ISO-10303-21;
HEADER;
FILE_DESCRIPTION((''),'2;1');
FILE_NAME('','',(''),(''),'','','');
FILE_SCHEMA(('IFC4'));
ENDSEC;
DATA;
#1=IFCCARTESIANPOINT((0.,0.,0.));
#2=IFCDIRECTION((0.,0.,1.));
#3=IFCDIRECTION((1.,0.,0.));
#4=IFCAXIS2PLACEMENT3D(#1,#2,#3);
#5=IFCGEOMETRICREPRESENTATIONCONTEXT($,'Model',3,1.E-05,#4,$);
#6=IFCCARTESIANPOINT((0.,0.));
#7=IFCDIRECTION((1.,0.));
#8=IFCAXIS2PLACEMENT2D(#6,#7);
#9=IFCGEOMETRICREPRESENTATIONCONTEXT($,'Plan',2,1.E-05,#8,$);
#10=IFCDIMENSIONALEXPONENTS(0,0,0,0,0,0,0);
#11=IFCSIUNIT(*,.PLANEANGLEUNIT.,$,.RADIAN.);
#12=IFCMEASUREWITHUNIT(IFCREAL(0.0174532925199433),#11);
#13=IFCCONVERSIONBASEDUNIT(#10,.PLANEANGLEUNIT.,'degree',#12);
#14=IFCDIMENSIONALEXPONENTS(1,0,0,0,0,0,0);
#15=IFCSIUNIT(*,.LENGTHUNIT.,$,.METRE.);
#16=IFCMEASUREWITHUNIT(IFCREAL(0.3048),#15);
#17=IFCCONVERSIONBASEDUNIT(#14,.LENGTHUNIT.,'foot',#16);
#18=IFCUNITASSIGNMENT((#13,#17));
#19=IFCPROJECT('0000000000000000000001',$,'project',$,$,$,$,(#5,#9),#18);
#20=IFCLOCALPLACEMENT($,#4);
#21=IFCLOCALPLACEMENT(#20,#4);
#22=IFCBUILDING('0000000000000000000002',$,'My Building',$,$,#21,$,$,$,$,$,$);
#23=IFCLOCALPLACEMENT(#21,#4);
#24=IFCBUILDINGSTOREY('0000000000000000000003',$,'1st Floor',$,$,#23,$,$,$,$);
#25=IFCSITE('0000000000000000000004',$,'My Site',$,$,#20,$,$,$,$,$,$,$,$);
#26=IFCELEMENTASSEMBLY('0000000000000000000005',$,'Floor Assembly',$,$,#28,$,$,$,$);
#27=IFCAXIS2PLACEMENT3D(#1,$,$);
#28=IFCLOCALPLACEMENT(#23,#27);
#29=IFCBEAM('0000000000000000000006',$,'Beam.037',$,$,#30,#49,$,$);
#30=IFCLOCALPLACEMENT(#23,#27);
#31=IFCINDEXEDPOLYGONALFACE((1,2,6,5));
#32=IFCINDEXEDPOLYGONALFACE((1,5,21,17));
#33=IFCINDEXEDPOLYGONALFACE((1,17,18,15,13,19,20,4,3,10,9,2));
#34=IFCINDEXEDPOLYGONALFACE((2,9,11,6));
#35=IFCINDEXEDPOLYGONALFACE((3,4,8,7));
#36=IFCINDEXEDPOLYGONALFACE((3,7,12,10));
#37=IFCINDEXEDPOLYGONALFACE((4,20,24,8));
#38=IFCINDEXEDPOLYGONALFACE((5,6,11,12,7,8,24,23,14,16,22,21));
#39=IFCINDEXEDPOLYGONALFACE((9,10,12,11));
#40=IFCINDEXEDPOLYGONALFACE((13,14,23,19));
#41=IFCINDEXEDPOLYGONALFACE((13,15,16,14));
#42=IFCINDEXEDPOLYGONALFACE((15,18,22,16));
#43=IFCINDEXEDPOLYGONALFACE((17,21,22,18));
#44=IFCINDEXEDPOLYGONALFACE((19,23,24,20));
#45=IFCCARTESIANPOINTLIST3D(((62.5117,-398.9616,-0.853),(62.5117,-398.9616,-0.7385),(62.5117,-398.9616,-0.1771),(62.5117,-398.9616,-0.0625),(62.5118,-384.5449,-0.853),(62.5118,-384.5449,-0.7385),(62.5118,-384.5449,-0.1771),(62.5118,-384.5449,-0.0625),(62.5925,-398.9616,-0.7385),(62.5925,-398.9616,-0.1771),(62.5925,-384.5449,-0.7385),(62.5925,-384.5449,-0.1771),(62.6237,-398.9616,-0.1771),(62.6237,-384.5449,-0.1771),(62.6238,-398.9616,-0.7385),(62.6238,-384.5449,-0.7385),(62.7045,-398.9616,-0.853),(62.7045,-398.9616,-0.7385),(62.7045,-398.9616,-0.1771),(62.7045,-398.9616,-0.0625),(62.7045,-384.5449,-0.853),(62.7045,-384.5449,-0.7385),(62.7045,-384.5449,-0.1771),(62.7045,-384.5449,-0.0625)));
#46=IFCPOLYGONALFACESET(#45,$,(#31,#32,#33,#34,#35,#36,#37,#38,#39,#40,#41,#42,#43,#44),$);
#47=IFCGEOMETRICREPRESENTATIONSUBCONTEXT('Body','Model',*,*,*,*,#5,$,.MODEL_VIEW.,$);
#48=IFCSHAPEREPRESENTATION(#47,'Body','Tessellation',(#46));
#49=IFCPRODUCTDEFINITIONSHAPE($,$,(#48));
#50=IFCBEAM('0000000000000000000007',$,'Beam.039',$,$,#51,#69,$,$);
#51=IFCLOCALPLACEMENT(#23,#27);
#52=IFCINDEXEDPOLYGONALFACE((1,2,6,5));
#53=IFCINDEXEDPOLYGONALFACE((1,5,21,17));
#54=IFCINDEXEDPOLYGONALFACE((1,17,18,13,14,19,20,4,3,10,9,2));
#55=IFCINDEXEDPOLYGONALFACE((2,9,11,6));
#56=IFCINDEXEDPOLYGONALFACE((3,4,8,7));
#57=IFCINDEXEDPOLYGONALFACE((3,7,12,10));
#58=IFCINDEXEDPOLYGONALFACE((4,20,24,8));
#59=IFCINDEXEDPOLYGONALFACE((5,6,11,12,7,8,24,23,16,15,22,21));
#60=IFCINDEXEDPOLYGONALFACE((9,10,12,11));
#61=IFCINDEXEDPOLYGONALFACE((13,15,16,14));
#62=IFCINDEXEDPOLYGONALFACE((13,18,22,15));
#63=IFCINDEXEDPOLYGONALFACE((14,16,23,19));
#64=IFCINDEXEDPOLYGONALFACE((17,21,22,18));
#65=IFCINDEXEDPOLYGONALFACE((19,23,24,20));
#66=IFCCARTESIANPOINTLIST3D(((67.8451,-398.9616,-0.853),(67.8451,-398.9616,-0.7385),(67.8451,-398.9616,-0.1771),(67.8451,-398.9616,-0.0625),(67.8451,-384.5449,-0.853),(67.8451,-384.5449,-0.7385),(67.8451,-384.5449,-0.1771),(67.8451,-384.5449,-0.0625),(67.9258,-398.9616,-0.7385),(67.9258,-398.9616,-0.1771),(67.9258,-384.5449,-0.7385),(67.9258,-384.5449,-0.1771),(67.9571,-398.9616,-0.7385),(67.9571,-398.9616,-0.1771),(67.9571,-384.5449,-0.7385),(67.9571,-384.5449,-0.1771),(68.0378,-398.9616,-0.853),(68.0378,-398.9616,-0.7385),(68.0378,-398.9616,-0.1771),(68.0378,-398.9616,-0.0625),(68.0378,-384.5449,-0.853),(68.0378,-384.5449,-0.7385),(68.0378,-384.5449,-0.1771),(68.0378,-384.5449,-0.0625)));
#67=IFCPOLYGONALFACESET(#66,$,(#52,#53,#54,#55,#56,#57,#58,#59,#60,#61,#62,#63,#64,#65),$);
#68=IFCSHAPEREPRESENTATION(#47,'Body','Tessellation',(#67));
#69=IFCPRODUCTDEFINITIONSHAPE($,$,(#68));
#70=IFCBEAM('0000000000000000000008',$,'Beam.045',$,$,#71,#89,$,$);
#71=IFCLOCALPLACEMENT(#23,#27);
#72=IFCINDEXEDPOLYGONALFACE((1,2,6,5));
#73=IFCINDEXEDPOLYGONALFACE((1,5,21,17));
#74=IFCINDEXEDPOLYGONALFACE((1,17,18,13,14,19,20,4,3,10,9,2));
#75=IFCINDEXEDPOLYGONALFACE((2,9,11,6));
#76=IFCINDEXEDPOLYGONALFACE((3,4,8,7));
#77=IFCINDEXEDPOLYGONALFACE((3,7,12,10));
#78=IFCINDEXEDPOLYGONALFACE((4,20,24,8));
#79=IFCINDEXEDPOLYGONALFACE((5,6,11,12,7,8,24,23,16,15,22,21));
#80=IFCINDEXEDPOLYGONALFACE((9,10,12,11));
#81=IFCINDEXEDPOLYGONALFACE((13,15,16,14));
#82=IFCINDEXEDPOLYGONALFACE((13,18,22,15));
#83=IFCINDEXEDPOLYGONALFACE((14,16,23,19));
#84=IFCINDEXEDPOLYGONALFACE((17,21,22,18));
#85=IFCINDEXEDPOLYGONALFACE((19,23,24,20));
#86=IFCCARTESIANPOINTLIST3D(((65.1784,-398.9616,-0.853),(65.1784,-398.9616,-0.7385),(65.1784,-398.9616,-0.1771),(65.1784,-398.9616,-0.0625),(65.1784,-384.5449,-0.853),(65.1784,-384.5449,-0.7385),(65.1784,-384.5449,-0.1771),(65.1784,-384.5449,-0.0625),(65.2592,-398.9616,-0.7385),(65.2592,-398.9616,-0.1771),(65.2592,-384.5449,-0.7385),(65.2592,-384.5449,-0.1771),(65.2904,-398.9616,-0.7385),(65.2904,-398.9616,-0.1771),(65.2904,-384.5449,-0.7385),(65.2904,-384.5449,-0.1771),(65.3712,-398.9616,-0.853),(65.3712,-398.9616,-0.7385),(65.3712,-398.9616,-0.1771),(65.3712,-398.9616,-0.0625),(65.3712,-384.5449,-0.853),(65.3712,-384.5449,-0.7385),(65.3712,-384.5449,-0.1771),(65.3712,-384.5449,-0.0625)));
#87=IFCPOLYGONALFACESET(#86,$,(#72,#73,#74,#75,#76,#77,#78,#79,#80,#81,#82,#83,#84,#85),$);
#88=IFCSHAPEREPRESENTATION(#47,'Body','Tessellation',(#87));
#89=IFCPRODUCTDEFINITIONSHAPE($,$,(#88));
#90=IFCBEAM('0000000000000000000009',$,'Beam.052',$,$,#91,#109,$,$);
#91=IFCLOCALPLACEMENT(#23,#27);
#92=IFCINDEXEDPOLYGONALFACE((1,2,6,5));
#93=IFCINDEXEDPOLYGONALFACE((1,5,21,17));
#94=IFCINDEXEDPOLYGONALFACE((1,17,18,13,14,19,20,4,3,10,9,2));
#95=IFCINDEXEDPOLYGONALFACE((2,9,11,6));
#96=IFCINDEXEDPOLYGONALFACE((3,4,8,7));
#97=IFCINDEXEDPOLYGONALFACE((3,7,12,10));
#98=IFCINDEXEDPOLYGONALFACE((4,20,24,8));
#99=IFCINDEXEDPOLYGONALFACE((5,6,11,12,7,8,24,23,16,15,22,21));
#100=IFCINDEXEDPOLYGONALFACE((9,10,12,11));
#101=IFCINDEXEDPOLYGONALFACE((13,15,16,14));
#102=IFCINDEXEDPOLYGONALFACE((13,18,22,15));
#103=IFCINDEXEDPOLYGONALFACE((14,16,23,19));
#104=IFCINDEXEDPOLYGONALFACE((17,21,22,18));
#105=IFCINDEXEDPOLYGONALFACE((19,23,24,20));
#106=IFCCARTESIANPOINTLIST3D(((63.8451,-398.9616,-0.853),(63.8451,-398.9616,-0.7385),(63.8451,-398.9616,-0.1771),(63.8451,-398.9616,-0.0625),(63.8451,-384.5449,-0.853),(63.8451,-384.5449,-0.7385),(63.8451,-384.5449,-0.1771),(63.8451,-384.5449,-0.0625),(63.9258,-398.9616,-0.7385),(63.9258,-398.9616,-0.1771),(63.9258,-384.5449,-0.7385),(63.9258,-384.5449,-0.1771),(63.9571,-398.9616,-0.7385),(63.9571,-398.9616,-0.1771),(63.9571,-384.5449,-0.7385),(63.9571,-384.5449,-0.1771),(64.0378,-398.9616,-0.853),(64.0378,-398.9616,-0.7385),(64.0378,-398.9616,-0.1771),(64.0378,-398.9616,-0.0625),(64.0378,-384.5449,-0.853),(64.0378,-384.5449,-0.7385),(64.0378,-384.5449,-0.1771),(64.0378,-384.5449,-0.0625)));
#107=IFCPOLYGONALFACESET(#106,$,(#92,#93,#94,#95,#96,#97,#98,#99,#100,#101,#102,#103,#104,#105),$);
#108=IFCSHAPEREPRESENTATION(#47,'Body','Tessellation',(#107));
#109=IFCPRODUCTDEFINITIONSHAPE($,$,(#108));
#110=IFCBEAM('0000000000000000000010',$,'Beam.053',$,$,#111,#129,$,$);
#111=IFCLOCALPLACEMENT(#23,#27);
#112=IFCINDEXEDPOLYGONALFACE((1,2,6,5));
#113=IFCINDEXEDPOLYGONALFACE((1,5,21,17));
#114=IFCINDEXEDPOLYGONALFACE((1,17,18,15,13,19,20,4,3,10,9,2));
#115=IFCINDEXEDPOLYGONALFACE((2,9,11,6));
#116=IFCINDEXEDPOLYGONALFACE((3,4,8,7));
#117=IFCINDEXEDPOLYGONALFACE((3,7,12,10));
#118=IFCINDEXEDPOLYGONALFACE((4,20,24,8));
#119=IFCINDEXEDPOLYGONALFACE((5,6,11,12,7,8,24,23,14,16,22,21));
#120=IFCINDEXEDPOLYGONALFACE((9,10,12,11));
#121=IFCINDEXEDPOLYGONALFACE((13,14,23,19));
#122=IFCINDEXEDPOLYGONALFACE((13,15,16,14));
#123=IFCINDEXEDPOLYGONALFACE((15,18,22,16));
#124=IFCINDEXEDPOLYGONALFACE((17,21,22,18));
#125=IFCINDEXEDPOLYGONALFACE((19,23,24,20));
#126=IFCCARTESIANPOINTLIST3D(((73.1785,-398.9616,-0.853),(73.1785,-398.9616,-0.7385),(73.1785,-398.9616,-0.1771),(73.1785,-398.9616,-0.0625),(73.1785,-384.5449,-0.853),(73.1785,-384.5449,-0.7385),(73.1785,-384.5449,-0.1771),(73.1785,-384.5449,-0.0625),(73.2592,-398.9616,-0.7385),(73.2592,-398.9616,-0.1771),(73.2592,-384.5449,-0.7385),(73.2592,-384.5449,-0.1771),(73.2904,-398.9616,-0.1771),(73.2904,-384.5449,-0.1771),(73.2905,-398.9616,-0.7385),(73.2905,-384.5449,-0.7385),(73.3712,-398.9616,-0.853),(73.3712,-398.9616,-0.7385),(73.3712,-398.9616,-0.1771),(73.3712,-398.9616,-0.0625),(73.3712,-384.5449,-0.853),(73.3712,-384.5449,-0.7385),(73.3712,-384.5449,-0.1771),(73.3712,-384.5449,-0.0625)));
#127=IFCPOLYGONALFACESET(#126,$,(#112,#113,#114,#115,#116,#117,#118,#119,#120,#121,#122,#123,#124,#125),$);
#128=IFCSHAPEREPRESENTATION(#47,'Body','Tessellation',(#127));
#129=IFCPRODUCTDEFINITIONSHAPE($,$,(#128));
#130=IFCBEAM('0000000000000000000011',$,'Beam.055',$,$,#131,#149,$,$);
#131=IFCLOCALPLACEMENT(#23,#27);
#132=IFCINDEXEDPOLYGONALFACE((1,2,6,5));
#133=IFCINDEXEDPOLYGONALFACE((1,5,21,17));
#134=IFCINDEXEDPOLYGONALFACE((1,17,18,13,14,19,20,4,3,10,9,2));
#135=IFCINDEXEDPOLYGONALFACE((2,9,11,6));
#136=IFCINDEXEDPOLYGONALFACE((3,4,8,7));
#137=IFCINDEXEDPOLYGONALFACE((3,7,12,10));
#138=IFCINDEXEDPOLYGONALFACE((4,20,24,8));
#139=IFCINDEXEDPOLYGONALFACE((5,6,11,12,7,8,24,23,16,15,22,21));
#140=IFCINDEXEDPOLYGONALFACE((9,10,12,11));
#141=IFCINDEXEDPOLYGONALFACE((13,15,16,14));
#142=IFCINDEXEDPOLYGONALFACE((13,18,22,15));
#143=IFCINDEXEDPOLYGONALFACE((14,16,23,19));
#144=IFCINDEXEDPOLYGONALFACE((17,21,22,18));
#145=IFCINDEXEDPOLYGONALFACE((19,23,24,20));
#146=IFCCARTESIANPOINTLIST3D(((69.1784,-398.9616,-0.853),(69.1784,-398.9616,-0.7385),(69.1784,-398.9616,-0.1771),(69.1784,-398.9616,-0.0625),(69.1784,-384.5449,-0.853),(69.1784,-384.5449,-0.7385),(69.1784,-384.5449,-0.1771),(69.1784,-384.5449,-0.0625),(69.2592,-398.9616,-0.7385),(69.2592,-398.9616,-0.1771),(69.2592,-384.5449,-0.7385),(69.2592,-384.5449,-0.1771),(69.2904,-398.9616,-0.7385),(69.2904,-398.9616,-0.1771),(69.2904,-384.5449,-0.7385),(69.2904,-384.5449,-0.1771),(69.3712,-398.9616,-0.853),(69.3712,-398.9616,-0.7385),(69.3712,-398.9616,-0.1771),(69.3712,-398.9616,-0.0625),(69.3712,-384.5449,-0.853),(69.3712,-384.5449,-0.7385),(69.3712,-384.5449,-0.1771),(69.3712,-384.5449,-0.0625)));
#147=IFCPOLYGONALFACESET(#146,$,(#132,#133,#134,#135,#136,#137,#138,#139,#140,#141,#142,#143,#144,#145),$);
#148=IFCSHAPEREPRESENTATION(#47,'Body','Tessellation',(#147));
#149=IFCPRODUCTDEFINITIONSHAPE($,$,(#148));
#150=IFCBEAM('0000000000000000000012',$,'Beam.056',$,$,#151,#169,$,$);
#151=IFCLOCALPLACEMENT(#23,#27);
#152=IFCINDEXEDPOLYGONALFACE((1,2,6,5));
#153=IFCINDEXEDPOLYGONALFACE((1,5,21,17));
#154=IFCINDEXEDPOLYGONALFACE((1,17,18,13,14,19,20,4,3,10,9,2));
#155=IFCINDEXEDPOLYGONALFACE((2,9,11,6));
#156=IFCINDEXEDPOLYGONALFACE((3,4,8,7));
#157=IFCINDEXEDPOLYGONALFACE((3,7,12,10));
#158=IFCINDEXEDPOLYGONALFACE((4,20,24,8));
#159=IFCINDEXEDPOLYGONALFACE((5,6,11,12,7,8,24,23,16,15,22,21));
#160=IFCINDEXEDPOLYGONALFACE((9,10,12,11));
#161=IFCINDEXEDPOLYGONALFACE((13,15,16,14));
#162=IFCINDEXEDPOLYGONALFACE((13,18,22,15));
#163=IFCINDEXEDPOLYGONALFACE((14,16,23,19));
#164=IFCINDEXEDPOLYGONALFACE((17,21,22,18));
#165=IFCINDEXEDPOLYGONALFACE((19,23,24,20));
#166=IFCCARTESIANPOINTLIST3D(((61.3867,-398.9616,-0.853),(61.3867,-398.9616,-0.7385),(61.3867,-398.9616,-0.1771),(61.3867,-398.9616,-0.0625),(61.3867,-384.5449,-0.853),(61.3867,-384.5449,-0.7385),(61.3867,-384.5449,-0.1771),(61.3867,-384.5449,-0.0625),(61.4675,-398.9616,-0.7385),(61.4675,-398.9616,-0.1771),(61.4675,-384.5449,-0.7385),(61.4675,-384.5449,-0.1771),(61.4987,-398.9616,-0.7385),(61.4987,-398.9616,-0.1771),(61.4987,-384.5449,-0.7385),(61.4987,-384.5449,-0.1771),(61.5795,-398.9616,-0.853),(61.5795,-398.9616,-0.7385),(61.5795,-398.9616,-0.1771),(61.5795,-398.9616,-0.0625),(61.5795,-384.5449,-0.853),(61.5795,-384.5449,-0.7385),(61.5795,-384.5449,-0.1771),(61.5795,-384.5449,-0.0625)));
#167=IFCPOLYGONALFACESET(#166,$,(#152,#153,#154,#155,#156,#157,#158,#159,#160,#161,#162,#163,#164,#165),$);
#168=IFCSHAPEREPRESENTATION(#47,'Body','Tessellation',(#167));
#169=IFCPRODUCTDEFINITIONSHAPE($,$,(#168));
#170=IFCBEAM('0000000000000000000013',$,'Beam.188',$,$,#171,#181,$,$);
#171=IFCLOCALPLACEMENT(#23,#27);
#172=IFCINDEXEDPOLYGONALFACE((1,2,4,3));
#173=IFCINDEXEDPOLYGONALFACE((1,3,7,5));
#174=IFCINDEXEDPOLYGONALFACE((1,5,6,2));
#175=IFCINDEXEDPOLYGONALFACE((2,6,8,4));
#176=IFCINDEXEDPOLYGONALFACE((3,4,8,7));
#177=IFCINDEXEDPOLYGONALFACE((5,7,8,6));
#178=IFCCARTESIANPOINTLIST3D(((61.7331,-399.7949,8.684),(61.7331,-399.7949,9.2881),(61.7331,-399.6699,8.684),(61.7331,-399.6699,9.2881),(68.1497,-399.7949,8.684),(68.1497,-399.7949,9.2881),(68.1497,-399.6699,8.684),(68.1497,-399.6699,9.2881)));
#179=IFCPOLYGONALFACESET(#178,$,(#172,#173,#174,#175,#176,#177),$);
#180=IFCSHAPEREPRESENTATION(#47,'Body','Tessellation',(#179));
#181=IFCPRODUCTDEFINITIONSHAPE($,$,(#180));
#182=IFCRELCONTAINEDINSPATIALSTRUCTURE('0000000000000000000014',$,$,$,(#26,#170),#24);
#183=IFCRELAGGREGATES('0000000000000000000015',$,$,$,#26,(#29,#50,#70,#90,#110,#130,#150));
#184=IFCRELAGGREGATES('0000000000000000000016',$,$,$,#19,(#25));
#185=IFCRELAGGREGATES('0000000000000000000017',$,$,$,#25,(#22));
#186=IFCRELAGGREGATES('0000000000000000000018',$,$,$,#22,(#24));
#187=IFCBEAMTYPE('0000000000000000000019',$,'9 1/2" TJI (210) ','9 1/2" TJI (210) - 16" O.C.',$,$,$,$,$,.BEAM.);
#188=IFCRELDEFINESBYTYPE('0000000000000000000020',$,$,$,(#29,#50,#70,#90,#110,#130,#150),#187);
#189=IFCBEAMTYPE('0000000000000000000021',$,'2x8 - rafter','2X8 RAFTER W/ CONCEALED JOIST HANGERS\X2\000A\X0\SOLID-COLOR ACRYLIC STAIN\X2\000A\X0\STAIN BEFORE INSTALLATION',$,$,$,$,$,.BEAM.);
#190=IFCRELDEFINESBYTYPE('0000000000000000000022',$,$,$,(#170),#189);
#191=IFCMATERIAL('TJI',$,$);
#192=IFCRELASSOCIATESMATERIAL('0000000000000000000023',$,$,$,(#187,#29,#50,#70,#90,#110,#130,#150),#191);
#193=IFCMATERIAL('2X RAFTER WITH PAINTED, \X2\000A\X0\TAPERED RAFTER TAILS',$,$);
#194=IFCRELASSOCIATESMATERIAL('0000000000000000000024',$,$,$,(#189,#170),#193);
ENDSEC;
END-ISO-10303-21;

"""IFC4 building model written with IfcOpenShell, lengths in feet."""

from ifc_helpers import new_model, entity, si_unit, converted_unit, frame, origin_with_axes, origin_2d_with_axis, place, context, subcontext, project, spatial, indexed_curve, rectangle, outline, extrude, material, material_profile, profile_set, profile_usage, type_object, element, aggregate, save


model = new_model("IFC4")

# Units and contexts
model_context = context("Model", 3, precision=1e-05, world=origin_with_axes())
plan_context = context("Plan", 2, precision=1e-05, world=origin_2d_with_axis())
body_context = subcontext(model_context, "Body", "Model", "MODEL_VIEW")
ifc_project = project(units=[converted_unit("PLANEANGLEUNIT", "degree", entity("IfcReal", 0.0174532925199433), si_unit("PLANEANGLEUNIT", "RADIAN"), dimensions=[0, 0, 0, 0, 0, 0, 0]), converted_unit("LENGTHUNIT", "foot", entity("IfcReal", 0.3048), si_unit("LENGTHUNIT", "METRE"), dimensions=[1, 0, 0, 0, 0, 0, 0])], contexts=[model_context, plan_context])

# Site, building, storey
site_placement = place(None, origin_with_axes())
site = spatial("IfcSite", under=ifc_project, at=site_placement, Name="My Site")
building_placement = place(site_placement, origin_with_axes())
building = spatial("IfcBuilding", under=site, at=building_placement, Name="My Building")
storey_placement = place(building_placement, origin_with_axes())
storey = spatial("IfcBuildingStorey", under=building, at=storey_placement, Name="1st Floor")

# Element assembly
assembly_1_placement = place(storey_placement, frame((61.1784, -398.9616, -0.0625), z_axis=(0.0, 0.0, 1.0), x_axis=(0.0, 1.0, 0.0)))
assembly_1 = element("IfcElementAssembly", 1, at=assembly_1_placement, inside=storey, Name="Floor Assembly")

# Beams
ifc_material_1 = material(Name="TJI")
ifc_material_profile_1 = material_profile(ifc_material_1, outline(indexed_curve([(0.0964, 0.7905), (-0.0964, 0.7905), (-0.0964, 0.6759), (-0.0156, 0.6759), (-0.0156, 0.1146), (-0.0964, 0.1146), (-0.0964, 0.0), (0.0964, 0.0), (0.0964, 0.1146), (0.0156, 0.1146), (0.0157, 0.6759), (0.0964, 0.6759), (0.0964, 0.7905)])))
ifc_profile_set_1 = profile_set([ifc_material_profile_1])
beam_type_1 = type_object("IfcBeamType", Name="9 1/2\" TJI (210) ", Description="9 1/2\" TJI (210) - 16\" O.C.", PredefinedType="BEAM", material=ifc_profile_set_1)
ifc_profile_usage_1 = profile_usage(ifc_profile_set_1, cardinal=5)
beam_1_placement = place(assembly_1_placement, frame((0.0, -1.4297, -0.7905), z_axis=(1.0, 0.0, 0.0), x_axis=(0.0, 1.0, 0.0)))
beam_1 = element("IfcBeam", 2, at=beam_1_placement, type_object=beam_type_1, material=ifc_profile_usage_1, Name="Beam.037", context=body_context, shape_type="SweptSolid", body=[
    extrude(outline(indexed_curve([(0.0964, 0.7905), (-0.0964, 0.7905), (-0.0964, 0.6759), (-0.0156, 0.6759), (-0.0156, 0.1146), (-0.0964, 0.1146), (-0.0964, 0.0), (0.0964, 0.0), (0.0964, 0.1146), (0.0156, 0.1146), (0.0157, 0.6759), (0.0964, 0.6759), (0.0964, 0.7905)])), origin_with_axes(), (0.0, 0.0, 1.0), 14.4167),
])
ifc_profile_usage_2 = profile_usage(ifc_profile_set_1, cardinal=5)
beam_2_placement = place(assembly_1_placement, frame((0.0, -6.763, -0.7905), z_axis=(1.0, 0.0, 0.0), x_axis=(0.0, 1.0, 0.0)))
beam_2 = element("IfcBeam", 3, at=beam_2_placement, type_object=beam_type_1, material=ifc_profile_usage_2, Name="Beam.039", context=body_context, shape_type="SweptSolid", body=[
    extrude(outline(indexed_curve([(0.0964, 0.7905), (-0.0964, 0.7905), (-0.0964, 0.6759), (-0.0156, 0.6759), (-0.0156, 0.1146), (-0.0964, 0.1146), (-0.0964, 0.0), (0.0964, 0.0), (0.0964, 0.1146), (0.0156, 0.1146), (0.0157, 0.6759), (0.0964, 0.6759), (0.0964, 0.7905)])), origin_with_axes(), (0.0, 0.0, 1.0), 14.4167),
])
ifc_profile_usage_3 = profile_usage(ifc_profile_set_1, cardinal=5)
beam_3_placement = place(assembly_1_placement, frame((0.0, -4.0964, -0.7905), z_axis=(1.0, 0.0, 0.0), x_axis=(0.0, 1.0, 0.0)))
beam_3 = element("IfcBeam", 4, at=beam_3_placement, type_object=beam_type_1, material=ifc_profile_usage_3, Name="Beam.045", context=body_context, shape_type="SweptSolid", body=[
    extrude(outline(indexed_curve([(0.0964, 0.7905), (-0.0964, 0.7905), (-0.0964, 0.6759), (-0.0156, 0.6759), (-0.0156, 0.1146), (-0.0964, 0.1146), (-0.0964, 0.0), (0.0964, 0.0), (0.0964, 0.1146), (0.0156, 0.1146), (0.0157, 0.6759), (0.0964, 0.6759), (0.0964, 0.7905)])), origin_with_axes(), (0.0, 0.0, 1.0), 14.4167),
])
ifc_profile_usage_4 = profile_usage(ifc_profile_set_1, cardinal=5)
beam_4_placement = place(assembly_1_placement, frame((0.0, -2.763, -0.7905), z_axis=(1.0, 0.0, 0.0), x_axis=(0.0, 1.0, 0.0)))
beam_4 = element("IfcBeam", 5, at=beam_4_placement, type_object=beam_type_1, material=ifc_profile_usage_4, Name="Beam.052", context=body_context, shape_type="SweptSolid", body=[
    extrude(outline(indexed_curve([(0.0964, 0.7905), (-0.0964, 0.7905), (-0.0964, 0.6759), (-0.0156, 0.6759), (-0.0156, 0.1146), (-0.0964, 0.1146), (-0.0964, 0.0), (0.0964, 0.0), (0.0964, 0.1146), (0.0156, 0.1146), (0.0157, 0.6759), (0.0964, 0.6759), (0.0964, 0.7905)])), origin_with_axes(), (0.0, 0.0, 1.0), 14.4167),
])
ifc_profile_usage_5 = profile_usage(ifc_profile_set_1, cardinal=5)
beam_5_placement = place(assembly_1_placement, frame((0.0, -12.0964, -0.7905), z_axis=(1.0, 0.0, 0.0), x_axis=(0.0, 1.0, 0.0)))
beam_5 = element("IfcBeam", 6, at=beam_5_placement, type_object=beam_type_1, material=ifc_profile_usage_5, Name="Beam.053", context=body_context, shape_type="SweptSolid", body=[
    extrude(outline(indexed_curve([(0.0964, 0.7905), (-0.0964, 0.7905), (-0.0964, 0.6759), (-0.0156, 0.6759), (-0.0156, 0.1146), (-0.0964, 0.1146), (-0.0964, 0.0), (0.0964, 0.0), (0.0964, 0.1146), (0.0156, 0.1146), (0.0157, 0.6759), (0.0964, 0.6759), (0.0964, 0.7905)])), origin_with_axes(), (0.0, 0.0, 1.0), 14.4167),
])
ifc_profile_usage_6 = profile_usage(ifc_profile_set_1, cardinal=5)
beam_6_placement = place(assembly_1_placement, frame((0.0, -8.0964, -0.7905), z_axis=(1.0, 0.0, 0.0), x_axis=(0.0, 1.0, 0.0)))
beam_6 = element("IfcBeam", 7, at=beam_6_placement, type_object=beam_type_1, material=ifc_profile_usage_6, Name="Beam.055", context=body_context, shape_type="SweptSolid", body=[
    extrude(outline(indexed_curve([(0.0964, 0.7905), (-0.0964, 0.7905), (-0.0964, 0.6759), (-0.0156, 0.6759), (-0.0156, 0.1146), (-0.0964, 0.1146), (-0.0964, 0.0), (0.0964, 0.0), (0.0964, 0.1146), (0.0156, 0.1146), (0.0157, 0.6759), (0.0964, 0.6759), (0.0964, 0.7905)])), origin_with_axes(), (0.0, 0.0, 1.0), 14.4167),
])
ifc_profile_usage_7 = profile_usage(ifc_profile_set_1, cardinal=5)
beam_7_placement = place(assembly_1_placement, frame((0.0, -0.3047, -0.7905), z_axis=(1.0, 0.0, 0.0), x_axis=(0.0, 1.0, 0.0)))
beam_7 = element("IfcBeam", 8, at=beam_7_placement, type_object=beam_type_1, material=ifc_profile_usage_7, Name="Beam.056", context=body_context, shape_type="SweptSolid", body=[
    extrude(outline(indexed_curve([(0.0964, 0.7905), (-0.0964, 0.7905), (-0.0964, 0.6759), (-0.0156, 0.6759), (-0.0156, 0.1146), (-0.0964, 0.1146), (-0.0964, 0.0), (0.0964, 0.0), (0.0964, 0.1146), (0.0156, 0.1146), (0.0157, 0.6759), (0.0964, 0.6759), (0.0964, 0.7905)])), origin_with_axes(), (0.0, 0.0, 1.0), 14.4167),
])
aggregate(assembly_1, [beam_1, beam_2, beam_3, beam_4, beam_5, beam_6, beam_7])
ifc_material_2 = material(Name="2X RAFTER WITH PAINTED, \nTAPERED RAFTER TAILS")
ifc_material_profile_2 = material_profile(ifc_material_2, rectangle(XDim=0.125, YDim=0.6042))
ifc_profile_set_2 = profile_set([ifc_material_profile_2])
ifc_profile_usage_8 = profile_usage(ifc_profile_set_2)
ifc_material_profile_3 = material_profile(ifc_material_2, rectangle(XDim=0.125, YDim=0.6042))
ifc_profile_set_3 = profile_set([ifc_material_profile_3])
beam_type_2 = type_object("IfcBeamType", Name="2x8 - rafter", Description="2X8 RAFTER W/ CONCEALED JOIST HANGERS\nSOLID-COLOR ACRYLIC STAIN\nSTAIN BEFORE INSTALLATION", PredefinedType="BEAM", material=ifc_profile_set_3)
beam_8_placement = place(storey_placement, frame((68.1497, -399.7324, 8.9861), z_axis=(-1.0, 0.0, 0.0), x_axis=(0.0, -1.0, 0.0)))
element("IfcBeam", 9, at=beam_8_placement, inside=storey, type_object=beam_type_2, material=ifc_profile_usage_8, Name="Beam.188", context=body_context, shape_type="SweptSolid", body=[
    extrude(rectangle(XDim=0.125, YDim=0.6042), origin_with_axes(), (0.0, 0.0, 1.0), 6.4167),
])

save(model, "model.ifc")
